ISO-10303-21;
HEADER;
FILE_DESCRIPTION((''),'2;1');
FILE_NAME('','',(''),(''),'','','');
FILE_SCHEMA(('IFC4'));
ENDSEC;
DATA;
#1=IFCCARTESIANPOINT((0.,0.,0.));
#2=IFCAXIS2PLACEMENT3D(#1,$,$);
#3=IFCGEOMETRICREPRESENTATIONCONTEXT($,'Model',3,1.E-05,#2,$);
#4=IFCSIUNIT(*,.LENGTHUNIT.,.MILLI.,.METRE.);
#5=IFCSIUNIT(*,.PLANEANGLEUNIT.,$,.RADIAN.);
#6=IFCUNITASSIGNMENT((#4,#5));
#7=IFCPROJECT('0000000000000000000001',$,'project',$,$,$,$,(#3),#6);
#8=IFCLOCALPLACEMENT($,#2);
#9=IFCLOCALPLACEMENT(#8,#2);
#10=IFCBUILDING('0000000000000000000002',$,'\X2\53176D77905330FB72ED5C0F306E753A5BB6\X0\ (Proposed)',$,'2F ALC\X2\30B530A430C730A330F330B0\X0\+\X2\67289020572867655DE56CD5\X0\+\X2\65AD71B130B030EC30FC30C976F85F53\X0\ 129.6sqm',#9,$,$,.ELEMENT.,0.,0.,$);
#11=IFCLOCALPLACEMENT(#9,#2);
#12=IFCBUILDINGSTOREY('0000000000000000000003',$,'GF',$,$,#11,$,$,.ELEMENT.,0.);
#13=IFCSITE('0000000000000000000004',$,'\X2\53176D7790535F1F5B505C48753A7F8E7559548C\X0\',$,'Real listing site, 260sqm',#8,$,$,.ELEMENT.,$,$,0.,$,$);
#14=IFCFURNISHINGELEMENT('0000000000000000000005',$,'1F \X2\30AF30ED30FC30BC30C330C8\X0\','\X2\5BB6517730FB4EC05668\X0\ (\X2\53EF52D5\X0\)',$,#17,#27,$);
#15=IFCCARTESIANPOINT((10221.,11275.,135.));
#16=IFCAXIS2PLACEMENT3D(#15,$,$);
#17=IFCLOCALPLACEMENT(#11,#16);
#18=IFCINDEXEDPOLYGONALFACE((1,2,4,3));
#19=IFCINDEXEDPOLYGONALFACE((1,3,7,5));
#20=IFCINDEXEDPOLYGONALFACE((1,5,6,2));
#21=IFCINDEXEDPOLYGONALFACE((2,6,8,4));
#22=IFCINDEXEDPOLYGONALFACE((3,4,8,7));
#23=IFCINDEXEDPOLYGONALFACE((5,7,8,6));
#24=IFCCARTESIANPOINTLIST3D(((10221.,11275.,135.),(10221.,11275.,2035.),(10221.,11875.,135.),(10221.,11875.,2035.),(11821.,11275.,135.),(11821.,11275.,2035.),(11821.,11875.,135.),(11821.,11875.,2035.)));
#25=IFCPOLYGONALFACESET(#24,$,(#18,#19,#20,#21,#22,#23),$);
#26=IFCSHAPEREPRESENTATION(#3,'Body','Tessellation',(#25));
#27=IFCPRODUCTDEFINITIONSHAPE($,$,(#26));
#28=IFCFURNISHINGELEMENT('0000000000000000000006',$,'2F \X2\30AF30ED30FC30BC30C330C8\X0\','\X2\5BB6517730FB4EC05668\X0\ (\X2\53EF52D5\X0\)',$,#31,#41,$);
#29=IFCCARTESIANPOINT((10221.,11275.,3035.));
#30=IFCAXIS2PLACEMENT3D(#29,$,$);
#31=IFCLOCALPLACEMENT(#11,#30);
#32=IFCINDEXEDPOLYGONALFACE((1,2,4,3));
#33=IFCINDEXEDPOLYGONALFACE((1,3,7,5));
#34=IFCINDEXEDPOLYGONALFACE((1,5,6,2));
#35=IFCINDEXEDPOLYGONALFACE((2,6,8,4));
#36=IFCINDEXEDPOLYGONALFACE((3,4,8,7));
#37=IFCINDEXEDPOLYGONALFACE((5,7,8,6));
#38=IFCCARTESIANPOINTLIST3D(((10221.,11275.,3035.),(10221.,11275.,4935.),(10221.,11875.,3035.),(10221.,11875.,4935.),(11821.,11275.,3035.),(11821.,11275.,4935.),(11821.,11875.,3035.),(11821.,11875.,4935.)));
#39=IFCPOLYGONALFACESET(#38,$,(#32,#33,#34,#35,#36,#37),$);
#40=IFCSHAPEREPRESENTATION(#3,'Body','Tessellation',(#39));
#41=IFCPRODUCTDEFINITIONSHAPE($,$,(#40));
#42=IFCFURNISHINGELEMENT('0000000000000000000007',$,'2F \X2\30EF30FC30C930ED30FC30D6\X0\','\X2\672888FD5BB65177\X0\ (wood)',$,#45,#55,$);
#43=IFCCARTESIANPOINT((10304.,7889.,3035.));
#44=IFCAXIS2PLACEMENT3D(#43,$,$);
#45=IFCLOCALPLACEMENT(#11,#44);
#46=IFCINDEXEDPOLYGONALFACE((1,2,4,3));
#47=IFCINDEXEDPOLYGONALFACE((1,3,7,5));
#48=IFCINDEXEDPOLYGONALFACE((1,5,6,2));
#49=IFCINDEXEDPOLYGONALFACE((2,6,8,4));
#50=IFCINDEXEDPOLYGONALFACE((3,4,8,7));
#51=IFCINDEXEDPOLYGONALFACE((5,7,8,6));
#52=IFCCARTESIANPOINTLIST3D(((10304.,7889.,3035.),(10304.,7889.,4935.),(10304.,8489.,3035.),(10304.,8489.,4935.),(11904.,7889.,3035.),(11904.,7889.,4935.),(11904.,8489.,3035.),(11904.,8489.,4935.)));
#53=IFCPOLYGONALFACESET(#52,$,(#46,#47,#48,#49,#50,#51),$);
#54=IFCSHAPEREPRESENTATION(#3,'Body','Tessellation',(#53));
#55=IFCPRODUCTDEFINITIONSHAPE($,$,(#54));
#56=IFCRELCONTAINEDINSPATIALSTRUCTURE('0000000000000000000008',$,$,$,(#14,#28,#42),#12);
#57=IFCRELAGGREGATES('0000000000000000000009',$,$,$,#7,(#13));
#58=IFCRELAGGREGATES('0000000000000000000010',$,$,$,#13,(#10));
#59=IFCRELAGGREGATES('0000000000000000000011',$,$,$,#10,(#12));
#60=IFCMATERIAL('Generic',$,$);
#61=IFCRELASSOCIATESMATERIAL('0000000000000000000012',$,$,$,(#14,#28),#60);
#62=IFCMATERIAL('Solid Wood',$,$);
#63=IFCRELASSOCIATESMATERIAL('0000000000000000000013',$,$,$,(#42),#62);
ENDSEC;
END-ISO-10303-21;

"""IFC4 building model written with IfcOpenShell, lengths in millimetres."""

from ifc_helpers import new_model, si_unit, frame, frame_2d, origin, place, context, project, spatial, rectangle, extrude, material, element, save


model = new_model("IFC4")

# Units and contexts
model_context = context("Model", 3, precision=1e-05, world=origin())
ifc_project = project(units=[si_unit("LENGTHUNIT", "METRE", prefix="MILLI"), si_unit("PLANEANGLEUNIT", "RADIAN")], contexts=[model_context])

# Site, building, storey
site_placement = place(None, origin())
site = spatial("IfcSite", under=ifc_project, at=site_placement, Name="北海道弟子屈町美留和", ObjectType="Real listing site, 260sqm", CompositionType="ELEMENT", RefElevation=0.0)
building_placement = place(site_placement, origin())
building = spatial("IfcBuilding", under=site, at=building_placement, Name="北海道・狭小の町家 (Proposed)", ObjectType="2F ALCサイディング+木造在来工法+断熱グレード相当 129.6sqm", CompositionType="ELEMENT", ElevationOfRefHeight=0.0, ElevationOfTerrain=0.0)
storey_placement = place(building_placement, origin())
storey = spatial("IfcBuildingStorey", under=building, at=storey_placement, Name="GF", CompositionType="ELEMENT", Elevation=0.0)

# Shared definitions
ifc_material_1 = material(Name="Solid Wood")

# Shared definitions
ifc_material_2 = material(Name="Generic")

# Furnishing elements
furnishing_1_placement = place(storey_placement, frame((10221.0, 11275.0, 135.0)))
element("IfcFurnishingElement", 1, at=furnishing_1_placement, inside=storey, material=ifc_material_2, Name="1F クローゼット", Description="家具・什器 (可動)", context=model_context, shape_type="SweptSolid", body=[
    extrude(rectangle(XDim=1600.0, YDim=600.0, at=frame_2d((800.0, 300.0))), frame((10221.0, 11275.0, 135.0)), (0.0, 0.0, 1.0), 1900.0),
])
furnishing_2_placement = place(storey_placement, frame((10221.0, 11275.0, 3035.0)))
element("IfcFurnishingElement", 2, at=furnishing_2_placement, inside=storey, material=ifc_material_2, Name="2F クローゼット", Description="家具・什器 (可動)", context=model_context, shape_type="SweptSolid", body=[
    extrude(rectangle(XDim=1600.0, YDim=600.0, at=frame_2d((800.0, 300.0))), frame((10221.0, 11275.0, 3035.0)), (0.0, 0.0, 1.0), 1900.0),
])
furnishing_3_placement = place(storey_placement, frame((10304.0, 7889.0, 3035.0)))
element("IfcFurnishingElement", 3, at=furnishing_3_placement, inside=storey, material=ifc_material_1, Name="2F ワードローブ", Description="木製家具 (wood)", context=model_context, shape_type="SweptSolid", body=[
    extrude(rectangle(XDim=1600.0, YDim=600.0, at=frame_2d((800.0, 300.0))), frame((10304.0, 7889.0, 3035.0)), (0.0, 0.0, 1.0), 1900.0),
])

save(model, "model.ifc")
